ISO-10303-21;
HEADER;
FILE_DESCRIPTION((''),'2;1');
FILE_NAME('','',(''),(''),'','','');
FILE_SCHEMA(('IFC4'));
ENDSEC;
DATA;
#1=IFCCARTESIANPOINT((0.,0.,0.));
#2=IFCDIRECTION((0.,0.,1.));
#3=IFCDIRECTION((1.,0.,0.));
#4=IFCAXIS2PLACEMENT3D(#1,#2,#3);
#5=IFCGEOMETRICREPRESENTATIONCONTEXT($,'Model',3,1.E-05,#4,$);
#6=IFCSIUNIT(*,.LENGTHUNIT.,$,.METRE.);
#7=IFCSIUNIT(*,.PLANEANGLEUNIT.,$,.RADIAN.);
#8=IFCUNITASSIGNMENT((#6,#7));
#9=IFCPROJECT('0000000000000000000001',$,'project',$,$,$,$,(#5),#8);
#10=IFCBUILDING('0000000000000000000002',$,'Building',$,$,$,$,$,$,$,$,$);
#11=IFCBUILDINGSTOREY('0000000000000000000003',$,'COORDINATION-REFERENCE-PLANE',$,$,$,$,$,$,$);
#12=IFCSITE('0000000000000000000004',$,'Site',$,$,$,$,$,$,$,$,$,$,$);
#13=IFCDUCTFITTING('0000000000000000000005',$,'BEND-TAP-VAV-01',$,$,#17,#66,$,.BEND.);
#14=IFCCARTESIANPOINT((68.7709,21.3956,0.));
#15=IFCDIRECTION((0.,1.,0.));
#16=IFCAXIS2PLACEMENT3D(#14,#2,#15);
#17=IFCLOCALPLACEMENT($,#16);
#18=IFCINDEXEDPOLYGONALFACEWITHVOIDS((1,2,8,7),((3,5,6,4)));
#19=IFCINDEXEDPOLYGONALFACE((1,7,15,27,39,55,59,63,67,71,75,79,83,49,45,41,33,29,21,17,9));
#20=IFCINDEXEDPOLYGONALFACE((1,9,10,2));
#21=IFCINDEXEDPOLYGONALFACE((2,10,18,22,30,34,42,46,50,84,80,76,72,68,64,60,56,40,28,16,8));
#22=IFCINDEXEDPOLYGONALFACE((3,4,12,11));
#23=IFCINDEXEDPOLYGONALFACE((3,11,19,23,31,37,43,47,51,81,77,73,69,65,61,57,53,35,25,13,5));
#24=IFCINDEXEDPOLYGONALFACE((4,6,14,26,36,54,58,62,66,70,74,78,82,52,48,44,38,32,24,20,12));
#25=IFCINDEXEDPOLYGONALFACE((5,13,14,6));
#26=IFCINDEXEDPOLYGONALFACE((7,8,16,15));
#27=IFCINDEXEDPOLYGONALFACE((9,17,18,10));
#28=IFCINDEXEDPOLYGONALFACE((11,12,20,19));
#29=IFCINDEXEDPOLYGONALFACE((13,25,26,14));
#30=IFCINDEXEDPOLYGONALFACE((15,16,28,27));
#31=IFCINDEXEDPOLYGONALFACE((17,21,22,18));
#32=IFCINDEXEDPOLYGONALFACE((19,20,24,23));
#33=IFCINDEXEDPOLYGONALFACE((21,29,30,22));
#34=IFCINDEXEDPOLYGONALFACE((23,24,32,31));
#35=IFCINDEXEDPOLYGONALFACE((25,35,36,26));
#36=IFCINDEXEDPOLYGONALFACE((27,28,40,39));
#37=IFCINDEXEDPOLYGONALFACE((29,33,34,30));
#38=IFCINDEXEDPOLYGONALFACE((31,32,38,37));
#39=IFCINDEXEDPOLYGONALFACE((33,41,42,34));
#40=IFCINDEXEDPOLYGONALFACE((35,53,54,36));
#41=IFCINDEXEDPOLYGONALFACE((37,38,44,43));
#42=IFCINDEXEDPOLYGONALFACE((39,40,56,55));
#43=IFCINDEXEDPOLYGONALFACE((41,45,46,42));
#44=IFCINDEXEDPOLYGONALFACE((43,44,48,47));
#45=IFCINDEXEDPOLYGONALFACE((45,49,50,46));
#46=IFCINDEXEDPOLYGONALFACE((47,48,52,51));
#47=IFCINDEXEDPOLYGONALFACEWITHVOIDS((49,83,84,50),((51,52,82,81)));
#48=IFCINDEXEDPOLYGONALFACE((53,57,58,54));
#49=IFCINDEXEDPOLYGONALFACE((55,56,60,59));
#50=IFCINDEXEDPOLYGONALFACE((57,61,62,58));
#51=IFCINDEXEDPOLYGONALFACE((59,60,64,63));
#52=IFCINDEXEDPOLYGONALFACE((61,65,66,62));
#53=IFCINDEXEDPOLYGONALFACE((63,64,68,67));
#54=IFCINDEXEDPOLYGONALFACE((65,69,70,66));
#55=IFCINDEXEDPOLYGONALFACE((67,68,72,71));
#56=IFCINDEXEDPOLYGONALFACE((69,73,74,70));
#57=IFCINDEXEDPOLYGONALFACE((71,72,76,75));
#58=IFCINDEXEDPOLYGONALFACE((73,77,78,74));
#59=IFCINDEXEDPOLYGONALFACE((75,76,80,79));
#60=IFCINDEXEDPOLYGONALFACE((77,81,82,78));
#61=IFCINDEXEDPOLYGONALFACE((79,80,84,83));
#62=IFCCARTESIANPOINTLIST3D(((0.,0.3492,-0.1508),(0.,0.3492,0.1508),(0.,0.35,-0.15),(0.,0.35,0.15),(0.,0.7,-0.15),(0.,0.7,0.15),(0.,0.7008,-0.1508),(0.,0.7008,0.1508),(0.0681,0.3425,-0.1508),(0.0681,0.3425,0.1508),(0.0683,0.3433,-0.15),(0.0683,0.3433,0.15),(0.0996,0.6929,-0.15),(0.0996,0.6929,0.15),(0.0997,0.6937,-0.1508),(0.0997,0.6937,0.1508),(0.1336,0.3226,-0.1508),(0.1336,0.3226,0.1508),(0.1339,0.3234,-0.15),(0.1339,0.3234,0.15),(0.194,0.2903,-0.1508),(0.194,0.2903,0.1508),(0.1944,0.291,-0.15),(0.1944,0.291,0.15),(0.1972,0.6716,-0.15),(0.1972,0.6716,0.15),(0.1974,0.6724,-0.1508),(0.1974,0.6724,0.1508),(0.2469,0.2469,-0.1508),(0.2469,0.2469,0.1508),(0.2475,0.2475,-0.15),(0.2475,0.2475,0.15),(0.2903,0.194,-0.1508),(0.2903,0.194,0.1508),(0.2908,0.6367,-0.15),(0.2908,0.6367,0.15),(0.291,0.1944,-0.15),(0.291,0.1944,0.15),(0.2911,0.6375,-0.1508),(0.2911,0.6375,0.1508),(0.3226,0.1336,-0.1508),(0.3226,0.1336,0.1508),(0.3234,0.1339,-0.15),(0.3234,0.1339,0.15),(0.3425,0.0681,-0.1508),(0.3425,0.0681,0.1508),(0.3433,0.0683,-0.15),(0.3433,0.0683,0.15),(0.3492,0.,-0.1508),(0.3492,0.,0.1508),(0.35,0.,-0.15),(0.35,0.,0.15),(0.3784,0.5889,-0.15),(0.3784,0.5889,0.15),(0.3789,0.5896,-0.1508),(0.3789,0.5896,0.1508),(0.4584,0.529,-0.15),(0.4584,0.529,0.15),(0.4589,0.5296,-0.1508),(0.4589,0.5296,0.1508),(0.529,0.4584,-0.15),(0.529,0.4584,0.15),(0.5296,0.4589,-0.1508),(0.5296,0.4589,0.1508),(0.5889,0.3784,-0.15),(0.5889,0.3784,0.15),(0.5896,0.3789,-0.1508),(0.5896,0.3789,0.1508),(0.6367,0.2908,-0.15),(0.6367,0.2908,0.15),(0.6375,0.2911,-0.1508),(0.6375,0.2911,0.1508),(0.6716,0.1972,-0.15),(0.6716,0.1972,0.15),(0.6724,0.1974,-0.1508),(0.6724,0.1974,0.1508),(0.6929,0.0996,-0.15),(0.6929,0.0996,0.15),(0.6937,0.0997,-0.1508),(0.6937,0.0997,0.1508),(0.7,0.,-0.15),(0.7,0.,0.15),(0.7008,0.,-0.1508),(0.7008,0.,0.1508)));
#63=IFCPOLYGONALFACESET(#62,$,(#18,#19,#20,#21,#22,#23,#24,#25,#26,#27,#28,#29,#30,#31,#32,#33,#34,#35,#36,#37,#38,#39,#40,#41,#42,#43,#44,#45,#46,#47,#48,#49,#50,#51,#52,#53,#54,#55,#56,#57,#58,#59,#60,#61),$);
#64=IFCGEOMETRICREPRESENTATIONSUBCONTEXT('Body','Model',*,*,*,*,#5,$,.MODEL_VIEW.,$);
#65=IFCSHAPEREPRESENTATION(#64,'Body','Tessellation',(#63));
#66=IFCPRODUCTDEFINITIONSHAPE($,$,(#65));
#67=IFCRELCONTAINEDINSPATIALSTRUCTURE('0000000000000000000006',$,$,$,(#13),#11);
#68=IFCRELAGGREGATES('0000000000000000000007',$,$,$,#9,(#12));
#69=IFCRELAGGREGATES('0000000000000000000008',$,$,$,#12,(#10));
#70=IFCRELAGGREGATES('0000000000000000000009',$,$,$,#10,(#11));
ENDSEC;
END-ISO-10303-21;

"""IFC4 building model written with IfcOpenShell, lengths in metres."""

from ifc_helpers import new_model, entity, si_unit, frame, origin_with_axes, place, context, subcontext, project, spatial, element, save


model = new_model("IFC4")

# Units and contexts
model_context = context("Model", 3, precision=1e-05, world=origin_with_axes())
body_context_1 = subcontext(model_context, "Body", "Model", "MODEL_VIEW")
ifc_project = project(units=[si_unit("LENGTHUNIT", "METRE"), si_unit("PLANEANGLEUNIT", "RADIAN")], contexts=[model_context])

# Site, building, storey
site = spatial("IfcSite", under=ifc_project, Name="Site")
building = spatial("IfcBuilding", under=site, Name="Building")
storey = spatial("IfcBuildingStorey", under=building, Name="COORDINATION-REFERENCE-PLANE")

# Duct fitting
duct_fitting_1_placement = place(None, frame((68.7709, 21.3956, 0.0), z_axis=(0.0, 0.0, 1.0), x_axis=(0.0, 1.0, 0.0)))
cartesian_point = entity("IfcCartesianPoint", [0.0, 0.0, 0.0])
element("IfcDuctFitting", 1, at=duct_fitting_1_placement, inside=storey, Name="BEND-TAP-VAV-01", PredefinedType="BEND", context=body_context_1, shape_type="SweptSolid", body=[
    entity("IfcRevolvedAreaSolid", entity("IfcRectangleHollowProfileDef", "AREA", None, entity("IfcAxis2Placement2D", entity("IfcCartesianPoint", [0.525, 0.0])), 0.3516, 0.3016, 0.0008), entity("IfcAxis2Placement3D", cartesian_point, entity("IfcDirection", [0.0, -1.0, 0.0]), entity("IfcDirection", [1.0, 0.0, 0.0])), entity("IfcAxis1Placement", cartesian_point, entity("IfcDirection", [0.0, 1.0, 0.0])), 1.570796),
])

save(model, "model.ifc")
